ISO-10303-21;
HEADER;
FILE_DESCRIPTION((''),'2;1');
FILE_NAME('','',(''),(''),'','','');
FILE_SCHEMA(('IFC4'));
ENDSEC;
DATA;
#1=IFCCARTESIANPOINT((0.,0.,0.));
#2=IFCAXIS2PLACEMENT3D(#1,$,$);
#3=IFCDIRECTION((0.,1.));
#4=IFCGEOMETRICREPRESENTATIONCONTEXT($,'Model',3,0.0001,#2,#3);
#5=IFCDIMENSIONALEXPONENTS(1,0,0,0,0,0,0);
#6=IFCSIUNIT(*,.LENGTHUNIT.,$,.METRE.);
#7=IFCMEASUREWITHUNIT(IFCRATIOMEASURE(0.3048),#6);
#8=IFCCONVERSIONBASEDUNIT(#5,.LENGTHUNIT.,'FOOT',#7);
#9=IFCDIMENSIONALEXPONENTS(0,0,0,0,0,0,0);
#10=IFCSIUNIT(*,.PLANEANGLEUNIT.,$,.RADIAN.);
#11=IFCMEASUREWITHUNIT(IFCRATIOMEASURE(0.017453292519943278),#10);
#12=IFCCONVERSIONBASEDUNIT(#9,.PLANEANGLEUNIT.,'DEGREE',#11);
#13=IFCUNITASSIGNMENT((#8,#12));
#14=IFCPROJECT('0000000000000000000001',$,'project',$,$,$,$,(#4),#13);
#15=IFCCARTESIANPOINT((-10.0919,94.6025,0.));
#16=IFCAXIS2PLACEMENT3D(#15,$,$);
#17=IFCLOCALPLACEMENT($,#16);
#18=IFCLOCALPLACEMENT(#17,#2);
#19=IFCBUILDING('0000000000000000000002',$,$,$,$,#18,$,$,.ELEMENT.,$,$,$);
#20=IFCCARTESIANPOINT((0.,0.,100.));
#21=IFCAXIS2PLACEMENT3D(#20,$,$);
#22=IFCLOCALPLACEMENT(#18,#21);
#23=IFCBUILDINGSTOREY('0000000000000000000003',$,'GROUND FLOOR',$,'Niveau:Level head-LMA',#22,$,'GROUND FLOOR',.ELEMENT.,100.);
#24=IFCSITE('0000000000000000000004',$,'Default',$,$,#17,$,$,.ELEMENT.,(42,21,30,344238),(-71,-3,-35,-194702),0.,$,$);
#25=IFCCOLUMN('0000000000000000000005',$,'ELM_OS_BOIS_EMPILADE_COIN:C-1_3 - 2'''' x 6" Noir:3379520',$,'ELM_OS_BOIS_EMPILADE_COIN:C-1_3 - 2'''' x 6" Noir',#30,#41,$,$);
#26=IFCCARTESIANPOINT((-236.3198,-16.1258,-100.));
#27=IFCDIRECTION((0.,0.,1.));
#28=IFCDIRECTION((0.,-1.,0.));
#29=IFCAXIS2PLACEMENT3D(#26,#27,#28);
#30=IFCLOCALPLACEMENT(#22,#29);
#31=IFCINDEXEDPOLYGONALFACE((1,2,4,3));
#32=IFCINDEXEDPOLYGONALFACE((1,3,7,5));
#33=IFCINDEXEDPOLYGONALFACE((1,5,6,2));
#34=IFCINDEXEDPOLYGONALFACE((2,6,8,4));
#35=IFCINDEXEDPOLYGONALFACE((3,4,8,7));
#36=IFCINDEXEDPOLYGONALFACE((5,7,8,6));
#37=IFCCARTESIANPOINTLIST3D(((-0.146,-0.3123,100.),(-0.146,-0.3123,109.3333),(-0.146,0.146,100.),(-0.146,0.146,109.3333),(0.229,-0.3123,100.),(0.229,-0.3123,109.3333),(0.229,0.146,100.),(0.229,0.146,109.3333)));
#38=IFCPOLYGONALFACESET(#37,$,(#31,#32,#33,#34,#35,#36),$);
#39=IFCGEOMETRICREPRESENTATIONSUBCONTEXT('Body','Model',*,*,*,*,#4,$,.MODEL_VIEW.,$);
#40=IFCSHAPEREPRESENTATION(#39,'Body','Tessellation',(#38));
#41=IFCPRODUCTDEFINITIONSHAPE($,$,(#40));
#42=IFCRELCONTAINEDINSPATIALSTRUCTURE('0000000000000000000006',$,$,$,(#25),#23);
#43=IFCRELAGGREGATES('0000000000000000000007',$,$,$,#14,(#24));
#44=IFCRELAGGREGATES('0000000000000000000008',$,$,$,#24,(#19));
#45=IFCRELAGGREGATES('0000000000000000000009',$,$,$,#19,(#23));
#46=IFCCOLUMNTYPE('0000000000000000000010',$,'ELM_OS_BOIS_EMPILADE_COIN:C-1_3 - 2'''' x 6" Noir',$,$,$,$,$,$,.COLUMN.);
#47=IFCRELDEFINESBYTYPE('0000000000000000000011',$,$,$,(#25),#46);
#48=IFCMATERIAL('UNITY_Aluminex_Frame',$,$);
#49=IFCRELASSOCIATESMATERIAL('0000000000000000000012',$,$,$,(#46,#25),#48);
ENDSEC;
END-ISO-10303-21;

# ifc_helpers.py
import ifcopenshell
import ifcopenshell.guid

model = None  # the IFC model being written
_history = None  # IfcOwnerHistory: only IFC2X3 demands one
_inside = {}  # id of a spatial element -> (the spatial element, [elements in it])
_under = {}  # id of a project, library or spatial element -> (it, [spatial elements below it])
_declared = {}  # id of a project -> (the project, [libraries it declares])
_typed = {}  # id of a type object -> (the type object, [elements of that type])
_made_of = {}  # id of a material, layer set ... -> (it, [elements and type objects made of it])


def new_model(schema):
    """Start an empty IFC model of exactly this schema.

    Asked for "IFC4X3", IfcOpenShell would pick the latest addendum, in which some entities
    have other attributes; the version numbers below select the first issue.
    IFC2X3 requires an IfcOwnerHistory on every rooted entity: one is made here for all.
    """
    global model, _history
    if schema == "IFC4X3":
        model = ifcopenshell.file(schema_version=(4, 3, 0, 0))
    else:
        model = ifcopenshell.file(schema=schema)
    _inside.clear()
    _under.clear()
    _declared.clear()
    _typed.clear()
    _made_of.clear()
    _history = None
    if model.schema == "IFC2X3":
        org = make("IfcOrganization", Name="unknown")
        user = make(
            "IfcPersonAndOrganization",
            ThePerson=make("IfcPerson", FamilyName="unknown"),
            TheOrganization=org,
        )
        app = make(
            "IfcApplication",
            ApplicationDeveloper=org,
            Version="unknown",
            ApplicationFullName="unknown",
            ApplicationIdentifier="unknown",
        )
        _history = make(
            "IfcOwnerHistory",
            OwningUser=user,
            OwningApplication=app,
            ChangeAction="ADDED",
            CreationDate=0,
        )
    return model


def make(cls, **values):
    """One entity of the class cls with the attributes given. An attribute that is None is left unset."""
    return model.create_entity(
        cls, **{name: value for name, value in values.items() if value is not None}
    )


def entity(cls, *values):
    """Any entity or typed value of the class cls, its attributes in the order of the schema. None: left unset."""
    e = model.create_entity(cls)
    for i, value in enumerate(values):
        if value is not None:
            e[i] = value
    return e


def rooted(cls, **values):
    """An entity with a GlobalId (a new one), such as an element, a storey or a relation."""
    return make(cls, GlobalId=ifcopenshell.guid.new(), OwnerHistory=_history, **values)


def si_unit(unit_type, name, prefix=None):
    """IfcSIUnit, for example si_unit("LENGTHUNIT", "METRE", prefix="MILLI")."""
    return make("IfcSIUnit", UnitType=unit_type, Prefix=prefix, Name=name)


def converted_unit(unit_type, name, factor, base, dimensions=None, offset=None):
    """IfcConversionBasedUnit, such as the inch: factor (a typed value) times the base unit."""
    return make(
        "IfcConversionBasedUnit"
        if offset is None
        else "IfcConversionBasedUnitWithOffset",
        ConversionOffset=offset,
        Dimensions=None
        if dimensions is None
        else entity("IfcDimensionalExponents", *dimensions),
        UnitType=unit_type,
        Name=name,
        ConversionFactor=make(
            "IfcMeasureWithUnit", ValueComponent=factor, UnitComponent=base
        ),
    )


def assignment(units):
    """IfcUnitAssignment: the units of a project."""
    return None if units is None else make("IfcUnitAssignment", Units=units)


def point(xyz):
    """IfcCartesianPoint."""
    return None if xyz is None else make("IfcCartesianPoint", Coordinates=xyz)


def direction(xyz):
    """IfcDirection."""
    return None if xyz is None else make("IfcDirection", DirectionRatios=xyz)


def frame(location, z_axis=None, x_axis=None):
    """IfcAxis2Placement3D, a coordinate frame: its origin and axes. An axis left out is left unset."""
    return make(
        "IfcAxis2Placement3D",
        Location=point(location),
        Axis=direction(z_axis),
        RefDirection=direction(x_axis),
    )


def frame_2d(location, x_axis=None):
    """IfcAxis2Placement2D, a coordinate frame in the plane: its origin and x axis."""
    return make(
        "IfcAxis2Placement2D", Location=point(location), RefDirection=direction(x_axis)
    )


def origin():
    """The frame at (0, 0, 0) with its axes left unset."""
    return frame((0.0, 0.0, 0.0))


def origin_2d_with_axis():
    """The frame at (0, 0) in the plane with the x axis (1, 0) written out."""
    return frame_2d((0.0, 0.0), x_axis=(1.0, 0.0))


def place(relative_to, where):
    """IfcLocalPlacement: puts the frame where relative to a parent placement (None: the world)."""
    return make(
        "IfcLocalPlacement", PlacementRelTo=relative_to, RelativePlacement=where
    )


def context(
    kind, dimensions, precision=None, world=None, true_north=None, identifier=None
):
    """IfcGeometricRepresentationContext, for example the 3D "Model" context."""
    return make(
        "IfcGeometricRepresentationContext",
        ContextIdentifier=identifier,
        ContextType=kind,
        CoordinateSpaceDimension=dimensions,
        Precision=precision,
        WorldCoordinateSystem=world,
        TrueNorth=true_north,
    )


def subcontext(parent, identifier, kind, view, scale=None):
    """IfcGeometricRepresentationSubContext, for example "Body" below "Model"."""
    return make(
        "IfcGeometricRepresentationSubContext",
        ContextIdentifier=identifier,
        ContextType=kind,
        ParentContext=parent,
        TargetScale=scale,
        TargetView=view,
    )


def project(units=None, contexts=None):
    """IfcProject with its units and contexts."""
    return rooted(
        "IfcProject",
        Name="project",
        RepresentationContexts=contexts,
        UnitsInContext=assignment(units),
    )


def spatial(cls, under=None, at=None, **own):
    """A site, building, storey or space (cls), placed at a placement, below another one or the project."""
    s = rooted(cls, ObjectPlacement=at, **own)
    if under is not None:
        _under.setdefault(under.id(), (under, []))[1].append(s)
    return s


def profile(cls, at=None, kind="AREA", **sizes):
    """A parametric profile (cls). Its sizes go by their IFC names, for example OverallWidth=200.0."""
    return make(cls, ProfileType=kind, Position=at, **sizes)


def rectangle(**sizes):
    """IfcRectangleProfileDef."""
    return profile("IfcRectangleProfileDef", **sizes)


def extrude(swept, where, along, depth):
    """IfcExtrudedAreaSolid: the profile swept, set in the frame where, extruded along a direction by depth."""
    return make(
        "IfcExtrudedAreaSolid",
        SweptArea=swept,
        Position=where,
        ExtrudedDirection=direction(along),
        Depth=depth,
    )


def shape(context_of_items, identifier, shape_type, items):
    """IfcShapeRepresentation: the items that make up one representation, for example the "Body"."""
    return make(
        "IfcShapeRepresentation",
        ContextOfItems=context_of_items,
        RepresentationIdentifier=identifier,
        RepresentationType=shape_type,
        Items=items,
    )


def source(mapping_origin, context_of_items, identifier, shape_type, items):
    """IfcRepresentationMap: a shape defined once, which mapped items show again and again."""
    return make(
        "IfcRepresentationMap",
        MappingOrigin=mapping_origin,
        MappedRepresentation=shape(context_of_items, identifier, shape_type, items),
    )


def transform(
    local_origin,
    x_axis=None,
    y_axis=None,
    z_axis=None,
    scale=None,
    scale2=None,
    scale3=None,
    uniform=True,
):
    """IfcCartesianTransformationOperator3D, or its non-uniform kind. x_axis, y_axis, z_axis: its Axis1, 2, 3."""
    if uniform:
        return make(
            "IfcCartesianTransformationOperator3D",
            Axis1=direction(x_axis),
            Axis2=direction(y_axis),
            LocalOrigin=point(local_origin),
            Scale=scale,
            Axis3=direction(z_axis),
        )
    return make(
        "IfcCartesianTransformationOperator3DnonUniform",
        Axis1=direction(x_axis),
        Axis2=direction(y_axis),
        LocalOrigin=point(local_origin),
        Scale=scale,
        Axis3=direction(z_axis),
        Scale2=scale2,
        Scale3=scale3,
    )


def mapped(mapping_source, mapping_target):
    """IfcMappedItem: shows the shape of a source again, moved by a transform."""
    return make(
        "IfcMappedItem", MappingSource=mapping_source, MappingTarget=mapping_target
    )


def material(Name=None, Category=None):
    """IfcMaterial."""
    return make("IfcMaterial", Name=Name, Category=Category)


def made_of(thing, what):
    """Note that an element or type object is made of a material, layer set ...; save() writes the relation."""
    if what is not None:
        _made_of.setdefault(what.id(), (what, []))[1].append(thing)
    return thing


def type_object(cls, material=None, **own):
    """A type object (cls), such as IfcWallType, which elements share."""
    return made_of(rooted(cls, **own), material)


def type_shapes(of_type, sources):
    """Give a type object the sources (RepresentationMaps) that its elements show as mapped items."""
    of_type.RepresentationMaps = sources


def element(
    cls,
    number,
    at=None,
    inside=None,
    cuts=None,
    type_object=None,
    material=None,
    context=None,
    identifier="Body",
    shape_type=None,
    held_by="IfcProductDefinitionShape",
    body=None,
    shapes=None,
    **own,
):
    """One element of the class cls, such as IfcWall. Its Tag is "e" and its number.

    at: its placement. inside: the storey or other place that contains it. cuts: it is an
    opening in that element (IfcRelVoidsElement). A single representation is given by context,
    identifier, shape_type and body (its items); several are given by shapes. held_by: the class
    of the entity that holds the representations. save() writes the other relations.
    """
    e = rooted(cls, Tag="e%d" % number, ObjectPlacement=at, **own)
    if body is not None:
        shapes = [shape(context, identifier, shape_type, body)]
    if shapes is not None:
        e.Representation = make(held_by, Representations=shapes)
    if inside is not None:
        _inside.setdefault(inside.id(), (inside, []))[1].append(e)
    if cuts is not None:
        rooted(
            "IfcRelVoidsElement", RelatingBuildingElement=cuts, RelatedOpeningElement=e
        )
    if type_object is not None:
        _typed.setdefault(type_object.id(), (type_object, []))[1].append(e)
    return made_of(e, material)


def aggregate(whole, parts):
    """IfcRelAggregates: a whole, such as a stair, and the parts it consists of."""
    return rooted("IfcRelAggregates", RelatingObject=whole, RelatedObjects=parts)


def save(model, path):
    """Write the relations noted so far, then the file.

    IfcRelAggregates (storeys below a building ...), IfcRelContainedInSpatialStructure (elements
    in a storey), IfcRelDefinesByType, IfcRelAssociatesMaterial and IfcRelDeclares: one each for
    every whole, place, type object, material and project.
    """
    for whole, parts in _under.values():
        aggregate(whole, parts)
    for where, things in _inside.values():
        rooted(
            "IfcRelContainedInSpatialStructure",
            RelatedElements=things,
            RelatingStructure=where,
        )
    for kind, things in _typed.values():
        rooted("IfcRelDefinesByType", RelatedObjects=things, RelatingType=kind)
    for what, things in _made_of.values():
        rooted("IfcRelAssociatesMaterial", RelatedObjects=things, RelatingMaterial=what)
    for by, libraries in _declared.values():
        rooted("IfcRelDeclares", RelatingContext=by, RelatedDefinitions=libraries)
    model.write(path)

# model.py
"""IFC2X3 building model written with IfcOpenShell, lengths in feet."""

from ifc_helpers import new_model, entity, si_unit, converted_unit, direction, frame, origin, origin_2d_with_axis, place, context, subcontext, project, spatial, rectangle, extrude, source, transform, mapped, material, type_object, type_shapes, element, save


model = new_model("IFC2X3")

# Units and contexts
model_context = context("Model", 3, precision=0.0001, world=origin(), true_north=direction((0.0, 1.0)))
body_context = subcontext(model_context, "Body", "Model", "MODEL_VIEW")
ifc_project = project(units=[converted_unit("LENGTHUNIT", "FOOT", entity("IfcRatioMeasure", 0.3048), si_unit("LENGTHUNIT", "METRE"), dimensions=[1, 0, 0, 0, 0, 0, 0]), converted_unit("PLANEANGLEUNIT", "DEGREE", entity("IfcRatioMeasure", 0.017453292519943278), si_unit("PLANEANGLEUNIT", "RADIAN"), dimensions=[0, 0, 0, 0, 0, 0, 0])], contexts=[model_context])

# Site, building, storey
site_placement = place(None, frame((-10.0919, 94.6025, 0.0)))
site = spatial("IfcSite", under=ifc_project, at=site_placement, Name="Default", CompositionType="ELEMENT", RefLatitude=(42, 21, 30, 344238), RefLongitude=(-71, -3, -35, -194702), RefElevation=0.0)
building_placement = place(site_placement, origin())
building = spatial("IfcBuilding", under=site, at=building_placement, CompositionType="ELEMENT")
storey_placement = place(building_placement, frame((0.0, 0.0, 100.0)))
storey = spatial("IfcBuildingStorey", under=building, at=storey_placement, Name="GROUND FLOOR", ObjectType="Niveau:Level head-LMA", LongName="GROUND FLOOR", CompositionType="ELEMENT", Elevation=100.0)

# Column
ifc_material_1 = material(Name="UNITY_Aluminex_Frame")
column_type = type_object("IfcColumnType", Name="ELM_OS_BOIS_EMPILADE_COIN:C-1_3 - 2'' x 6\" Noir", PredefinedType="COLUMN", material=ifc_material_1)
shared_shape = source(origin(), body_context, "Body", "SweptSolid", [
    extrude(rectangle(XDim=0.4583, YDim=0.375, at=origin_2d_with_axis()), frame((0.0415, -0.0832, 100.0), z_axis=(0.0, 0.0, 1.0), x_axis=(0.0, -1.0, 0.0)), (0.0, 0.0, 1.0), 9.3333),
])
type_shapes(column_type, [shared_shape])
column_placement = place(storey_placement, frame((-236.3198, -16.1258, -100.0), z_axis=(0.0, 0.0, 1.0), x_axis=(0.0, -1.0, 0.0)))
element("IfcColumn", 1, at=column_placement, inside=storey, type_object=column_type, material=ifc_material_1, Name="ELM_OS_BOIS_EMPILADE_COIN:C-1_3 - 2'' x 6\" Noir:3379520", ObjectType="ELM_OS_BOIS_EMPILADE_COIN:C-1_3 - 2'' x 6\" Noir", context=body_context, shape_type="MappedRepresentation", body=[
    mapped(shared_shape, transform((0.0, 0.0, 0.0), scale=1.0)),
])

save(model, "model.ifc")
